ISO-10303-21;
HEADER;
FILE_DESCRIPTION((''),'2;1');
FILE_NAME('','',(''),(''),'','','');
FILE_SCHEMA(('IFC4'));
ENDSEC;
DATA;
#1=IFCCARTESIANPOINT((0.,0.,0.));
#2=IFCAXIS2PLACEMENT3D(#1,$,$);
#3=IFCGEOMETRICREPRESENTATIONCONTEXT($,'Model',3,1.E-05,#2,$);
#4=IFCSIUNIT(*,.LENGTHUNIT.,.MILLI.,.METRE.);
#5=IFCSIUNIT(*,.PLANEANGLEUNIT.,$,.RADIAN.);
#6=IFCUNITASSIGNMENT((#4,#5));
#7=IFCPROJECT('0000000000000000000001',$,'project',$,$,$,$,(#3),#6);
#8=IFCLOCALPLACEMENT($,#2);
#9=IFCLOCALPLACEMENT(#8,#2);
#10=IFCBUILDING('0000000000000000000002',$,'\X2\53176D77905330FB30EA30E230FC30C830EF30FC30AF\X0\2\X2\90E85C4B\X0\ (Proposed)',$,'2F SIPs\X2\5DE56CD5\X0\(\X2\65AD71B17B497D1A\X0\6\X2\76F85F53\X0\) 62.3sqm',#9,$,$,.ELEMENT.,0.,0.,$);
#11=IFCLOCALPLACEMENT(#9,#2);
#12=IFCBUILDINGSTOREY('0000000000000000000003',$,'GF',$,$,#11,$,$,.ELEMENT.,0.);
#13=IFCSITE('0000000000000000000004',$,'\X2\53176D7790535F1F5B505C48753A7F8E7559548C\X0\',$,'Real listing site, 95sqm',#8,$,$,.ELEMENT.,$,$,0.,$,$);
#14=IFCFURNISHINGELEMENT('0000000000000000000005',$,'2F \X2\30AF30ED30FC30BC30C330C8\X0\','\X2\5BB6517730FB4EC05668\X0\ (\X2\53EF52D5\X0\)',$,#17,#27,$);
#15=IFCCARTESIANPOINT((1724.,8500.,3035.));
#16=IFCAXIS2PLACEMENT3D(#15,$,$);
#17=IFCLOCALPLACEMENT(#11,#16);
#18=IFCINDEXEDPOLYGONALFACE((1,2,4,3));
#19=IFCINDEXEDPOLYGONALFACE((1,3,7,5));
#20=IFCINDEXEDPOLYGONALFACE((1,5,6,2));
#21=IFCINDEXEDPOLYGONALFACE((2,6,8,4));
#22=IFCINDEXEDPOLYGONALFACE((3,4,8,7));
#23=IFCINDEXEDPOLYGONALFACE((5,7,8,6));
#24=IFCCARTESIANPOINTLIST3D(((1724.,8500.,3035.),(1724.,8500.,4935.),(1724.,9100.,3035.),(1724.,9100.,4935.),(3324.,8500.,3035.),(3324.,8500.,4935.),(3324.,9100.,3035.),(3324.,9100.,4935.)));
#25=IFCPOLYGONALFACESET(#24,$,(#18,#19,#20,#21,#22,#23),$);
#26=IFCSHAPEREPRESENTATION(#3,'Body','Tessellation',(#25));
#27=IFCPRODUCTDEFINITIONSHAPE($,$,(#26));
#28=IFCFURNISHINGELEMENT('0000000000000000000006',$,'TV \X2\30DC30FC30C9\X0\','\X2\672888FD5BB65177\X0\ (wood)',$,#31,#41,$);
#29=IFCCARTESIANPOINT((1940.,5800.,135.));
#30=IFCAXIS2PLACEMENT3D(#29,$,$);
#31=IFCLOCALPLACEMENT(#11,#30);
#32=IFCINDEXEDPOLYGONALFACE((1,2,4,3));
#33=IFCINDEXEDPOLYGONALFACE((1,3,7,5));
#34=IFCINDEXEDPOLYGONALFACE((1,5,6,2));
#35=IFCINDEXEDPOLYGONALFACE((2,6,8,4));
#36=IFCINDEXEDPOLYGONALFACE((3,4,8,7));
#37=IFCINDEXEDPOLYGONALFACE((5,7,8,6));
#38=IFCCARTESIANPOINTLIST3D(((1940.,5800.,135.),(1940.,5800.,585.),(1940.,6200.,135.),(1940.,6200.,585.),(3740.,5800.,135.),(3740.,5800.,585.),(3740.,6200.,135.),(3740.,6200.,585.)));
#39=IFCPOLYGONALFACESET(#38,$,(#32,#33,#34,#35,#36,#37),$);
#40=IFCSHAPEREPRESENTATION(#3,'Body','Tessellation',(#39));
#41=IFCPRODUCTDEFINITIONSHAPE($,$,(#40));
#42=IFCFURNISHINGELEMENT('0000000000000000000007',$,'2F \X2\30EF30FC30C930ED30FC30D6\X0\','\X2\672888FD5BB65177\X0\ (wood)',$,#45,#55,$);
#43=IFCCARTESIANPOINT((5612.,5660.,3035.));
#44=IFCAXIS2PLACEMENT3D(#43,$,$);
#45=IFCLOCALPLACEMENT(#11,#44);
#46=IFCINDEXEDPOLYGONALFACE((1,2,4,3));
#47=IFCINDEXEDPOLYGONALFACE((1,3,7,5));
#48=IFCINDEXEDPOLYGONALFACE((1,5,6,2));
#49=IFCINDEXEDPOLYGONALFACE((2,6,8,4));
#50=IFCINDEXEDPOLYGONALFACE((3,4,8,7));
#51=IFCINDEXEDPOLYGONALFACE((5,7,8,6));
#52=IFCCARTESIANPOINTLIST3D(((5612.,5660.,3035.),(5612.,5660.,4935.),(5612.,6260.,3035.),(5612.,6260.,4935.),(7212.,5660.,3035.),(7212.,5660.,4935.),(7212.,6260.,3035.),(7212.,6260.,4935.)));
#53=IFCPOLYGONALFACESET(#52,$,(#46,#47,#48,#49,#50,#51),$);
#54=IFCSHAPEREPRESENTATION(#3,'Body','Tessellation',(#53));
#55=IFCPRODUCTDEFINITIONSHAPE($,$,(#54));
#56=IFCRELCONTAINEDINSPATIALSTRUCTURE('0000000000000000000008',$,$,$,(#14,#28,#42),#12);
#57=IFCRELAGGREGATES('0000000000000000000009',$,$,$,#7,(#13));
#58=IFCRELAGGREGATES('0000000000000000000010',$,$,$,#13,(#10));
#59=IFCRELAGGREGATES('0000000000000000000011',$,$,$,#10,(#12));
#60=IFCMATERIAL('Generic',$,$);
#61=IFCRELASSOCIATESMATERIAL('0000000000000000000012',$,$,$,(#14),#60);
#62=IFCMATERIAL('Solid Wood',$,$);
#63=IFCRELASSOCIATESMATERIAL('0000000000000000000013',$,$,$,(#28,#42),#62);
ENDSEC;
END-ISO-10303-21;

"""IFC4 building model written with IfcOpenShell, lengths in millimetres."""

from ifc_helpers import new_model, si_unit, frame, frame_2d, origin, place, context, project, spatial, rectangle, extrude, material, element, save


model = new_model("IFC4")

# Units and contexts
model_context = context("Model", 3, precision=1e-05, world=origin())
ifc_project = project(units=[si_unit("LENGTHUNIT", "METRE", prefix="MILLI"), si_unit("PLANEANGLEUNIT", "RADIAN")], contexts=[model_context])

# Site, building, storey
site_placement = place(None, origin())
site = spatial("IfcSite", under=ifc_project, at=site_placement, Name="北海道弟子屈町美留和", ObjectType="Real listing site, 95sqm", CompositionType="ELEMENT", RefElevation=0.0)
building_placement = place(site_placement, origin())
building = spatial("IfcBuilding", under=site, at=building_placement, Name="北海道・リモートワーク2部屋 (Proposed)", ObjectType="2F SIPs工法(断熱等級6相当) 62.3sqm", CompositionType="ELEMENT", ElevationOfRefHeight=0.0, ElevationOfTerrain=0.0)
storey_placement = place(building_placement, origin())
storey = spatial("IfcBuildingStorey", under=building, at=storey_placement, Name="GF", CompositionType="ELEMENT", Elevation=0.0)

# Shared definitions
ifc_material_1 = material(Name="Solid Wood")

# Shared definitions
ifc_material_2 = material(Name="Generic")

# Furnishing elements
furnishing_1_placement = place(storey_placement, frame((1724.0, 8500.0, 3035.0)))
element("IfcFurnishingElement", 1, at=furnishing_1_placement, inside=storey, material=ifc_material_2, Name="2F クローゼット", Description="家具・什器 (可動)", context=model_context, shape_type="SweptSolid", body=[
    extrude(rectangle(XDim=1600.0, YDim=600.0, at=frame_2d((800.0, 300.0))), frame((1724.0, 8500.0, 3035.0)), (0.0, 0.0, 1.0), 1900.0),
])
furnishing_2_placement = place(storey_placement, frame((1940.0, 5800.0, 135.0)))
element("IfcFurnishingElement", 2, at=furnishing_2_placement, inside=storey, material=ifc_material_1, Name="TV ボード", Description="木製家具 (wood)", context=model_context, shape_type="SweptSolid", body=[
    extrude(rectangle(XDim=1800.0, YDim=400.0, at=frame_2d((900.0, 200.0))), frame((1940.0, 5800.0, 135.0)), (0.0, 0.0, 1.0), 450.0),
])
furnishing_3_placement = place(storey_placement, frame((5612.0, 5660.0, 3035.0)))
element("IfcFurnishingElement", 3, at=furnishing_3_placement, inside=storey, material=ifc_material_1, Name="2F ワードローブ", Description="木製家具 (wood)", context=model_context, shape_type="SweptSolid", body=[
    extrude(rectangle(XDim=1600.0, YDim=600.0, at=frame_2d((800.0, 300.0))), frame((5612.0, 5660.0, 3035.0)), (0.0, 0.0, 1.0), 1900.0),
])

save(model, "model.ifc")
